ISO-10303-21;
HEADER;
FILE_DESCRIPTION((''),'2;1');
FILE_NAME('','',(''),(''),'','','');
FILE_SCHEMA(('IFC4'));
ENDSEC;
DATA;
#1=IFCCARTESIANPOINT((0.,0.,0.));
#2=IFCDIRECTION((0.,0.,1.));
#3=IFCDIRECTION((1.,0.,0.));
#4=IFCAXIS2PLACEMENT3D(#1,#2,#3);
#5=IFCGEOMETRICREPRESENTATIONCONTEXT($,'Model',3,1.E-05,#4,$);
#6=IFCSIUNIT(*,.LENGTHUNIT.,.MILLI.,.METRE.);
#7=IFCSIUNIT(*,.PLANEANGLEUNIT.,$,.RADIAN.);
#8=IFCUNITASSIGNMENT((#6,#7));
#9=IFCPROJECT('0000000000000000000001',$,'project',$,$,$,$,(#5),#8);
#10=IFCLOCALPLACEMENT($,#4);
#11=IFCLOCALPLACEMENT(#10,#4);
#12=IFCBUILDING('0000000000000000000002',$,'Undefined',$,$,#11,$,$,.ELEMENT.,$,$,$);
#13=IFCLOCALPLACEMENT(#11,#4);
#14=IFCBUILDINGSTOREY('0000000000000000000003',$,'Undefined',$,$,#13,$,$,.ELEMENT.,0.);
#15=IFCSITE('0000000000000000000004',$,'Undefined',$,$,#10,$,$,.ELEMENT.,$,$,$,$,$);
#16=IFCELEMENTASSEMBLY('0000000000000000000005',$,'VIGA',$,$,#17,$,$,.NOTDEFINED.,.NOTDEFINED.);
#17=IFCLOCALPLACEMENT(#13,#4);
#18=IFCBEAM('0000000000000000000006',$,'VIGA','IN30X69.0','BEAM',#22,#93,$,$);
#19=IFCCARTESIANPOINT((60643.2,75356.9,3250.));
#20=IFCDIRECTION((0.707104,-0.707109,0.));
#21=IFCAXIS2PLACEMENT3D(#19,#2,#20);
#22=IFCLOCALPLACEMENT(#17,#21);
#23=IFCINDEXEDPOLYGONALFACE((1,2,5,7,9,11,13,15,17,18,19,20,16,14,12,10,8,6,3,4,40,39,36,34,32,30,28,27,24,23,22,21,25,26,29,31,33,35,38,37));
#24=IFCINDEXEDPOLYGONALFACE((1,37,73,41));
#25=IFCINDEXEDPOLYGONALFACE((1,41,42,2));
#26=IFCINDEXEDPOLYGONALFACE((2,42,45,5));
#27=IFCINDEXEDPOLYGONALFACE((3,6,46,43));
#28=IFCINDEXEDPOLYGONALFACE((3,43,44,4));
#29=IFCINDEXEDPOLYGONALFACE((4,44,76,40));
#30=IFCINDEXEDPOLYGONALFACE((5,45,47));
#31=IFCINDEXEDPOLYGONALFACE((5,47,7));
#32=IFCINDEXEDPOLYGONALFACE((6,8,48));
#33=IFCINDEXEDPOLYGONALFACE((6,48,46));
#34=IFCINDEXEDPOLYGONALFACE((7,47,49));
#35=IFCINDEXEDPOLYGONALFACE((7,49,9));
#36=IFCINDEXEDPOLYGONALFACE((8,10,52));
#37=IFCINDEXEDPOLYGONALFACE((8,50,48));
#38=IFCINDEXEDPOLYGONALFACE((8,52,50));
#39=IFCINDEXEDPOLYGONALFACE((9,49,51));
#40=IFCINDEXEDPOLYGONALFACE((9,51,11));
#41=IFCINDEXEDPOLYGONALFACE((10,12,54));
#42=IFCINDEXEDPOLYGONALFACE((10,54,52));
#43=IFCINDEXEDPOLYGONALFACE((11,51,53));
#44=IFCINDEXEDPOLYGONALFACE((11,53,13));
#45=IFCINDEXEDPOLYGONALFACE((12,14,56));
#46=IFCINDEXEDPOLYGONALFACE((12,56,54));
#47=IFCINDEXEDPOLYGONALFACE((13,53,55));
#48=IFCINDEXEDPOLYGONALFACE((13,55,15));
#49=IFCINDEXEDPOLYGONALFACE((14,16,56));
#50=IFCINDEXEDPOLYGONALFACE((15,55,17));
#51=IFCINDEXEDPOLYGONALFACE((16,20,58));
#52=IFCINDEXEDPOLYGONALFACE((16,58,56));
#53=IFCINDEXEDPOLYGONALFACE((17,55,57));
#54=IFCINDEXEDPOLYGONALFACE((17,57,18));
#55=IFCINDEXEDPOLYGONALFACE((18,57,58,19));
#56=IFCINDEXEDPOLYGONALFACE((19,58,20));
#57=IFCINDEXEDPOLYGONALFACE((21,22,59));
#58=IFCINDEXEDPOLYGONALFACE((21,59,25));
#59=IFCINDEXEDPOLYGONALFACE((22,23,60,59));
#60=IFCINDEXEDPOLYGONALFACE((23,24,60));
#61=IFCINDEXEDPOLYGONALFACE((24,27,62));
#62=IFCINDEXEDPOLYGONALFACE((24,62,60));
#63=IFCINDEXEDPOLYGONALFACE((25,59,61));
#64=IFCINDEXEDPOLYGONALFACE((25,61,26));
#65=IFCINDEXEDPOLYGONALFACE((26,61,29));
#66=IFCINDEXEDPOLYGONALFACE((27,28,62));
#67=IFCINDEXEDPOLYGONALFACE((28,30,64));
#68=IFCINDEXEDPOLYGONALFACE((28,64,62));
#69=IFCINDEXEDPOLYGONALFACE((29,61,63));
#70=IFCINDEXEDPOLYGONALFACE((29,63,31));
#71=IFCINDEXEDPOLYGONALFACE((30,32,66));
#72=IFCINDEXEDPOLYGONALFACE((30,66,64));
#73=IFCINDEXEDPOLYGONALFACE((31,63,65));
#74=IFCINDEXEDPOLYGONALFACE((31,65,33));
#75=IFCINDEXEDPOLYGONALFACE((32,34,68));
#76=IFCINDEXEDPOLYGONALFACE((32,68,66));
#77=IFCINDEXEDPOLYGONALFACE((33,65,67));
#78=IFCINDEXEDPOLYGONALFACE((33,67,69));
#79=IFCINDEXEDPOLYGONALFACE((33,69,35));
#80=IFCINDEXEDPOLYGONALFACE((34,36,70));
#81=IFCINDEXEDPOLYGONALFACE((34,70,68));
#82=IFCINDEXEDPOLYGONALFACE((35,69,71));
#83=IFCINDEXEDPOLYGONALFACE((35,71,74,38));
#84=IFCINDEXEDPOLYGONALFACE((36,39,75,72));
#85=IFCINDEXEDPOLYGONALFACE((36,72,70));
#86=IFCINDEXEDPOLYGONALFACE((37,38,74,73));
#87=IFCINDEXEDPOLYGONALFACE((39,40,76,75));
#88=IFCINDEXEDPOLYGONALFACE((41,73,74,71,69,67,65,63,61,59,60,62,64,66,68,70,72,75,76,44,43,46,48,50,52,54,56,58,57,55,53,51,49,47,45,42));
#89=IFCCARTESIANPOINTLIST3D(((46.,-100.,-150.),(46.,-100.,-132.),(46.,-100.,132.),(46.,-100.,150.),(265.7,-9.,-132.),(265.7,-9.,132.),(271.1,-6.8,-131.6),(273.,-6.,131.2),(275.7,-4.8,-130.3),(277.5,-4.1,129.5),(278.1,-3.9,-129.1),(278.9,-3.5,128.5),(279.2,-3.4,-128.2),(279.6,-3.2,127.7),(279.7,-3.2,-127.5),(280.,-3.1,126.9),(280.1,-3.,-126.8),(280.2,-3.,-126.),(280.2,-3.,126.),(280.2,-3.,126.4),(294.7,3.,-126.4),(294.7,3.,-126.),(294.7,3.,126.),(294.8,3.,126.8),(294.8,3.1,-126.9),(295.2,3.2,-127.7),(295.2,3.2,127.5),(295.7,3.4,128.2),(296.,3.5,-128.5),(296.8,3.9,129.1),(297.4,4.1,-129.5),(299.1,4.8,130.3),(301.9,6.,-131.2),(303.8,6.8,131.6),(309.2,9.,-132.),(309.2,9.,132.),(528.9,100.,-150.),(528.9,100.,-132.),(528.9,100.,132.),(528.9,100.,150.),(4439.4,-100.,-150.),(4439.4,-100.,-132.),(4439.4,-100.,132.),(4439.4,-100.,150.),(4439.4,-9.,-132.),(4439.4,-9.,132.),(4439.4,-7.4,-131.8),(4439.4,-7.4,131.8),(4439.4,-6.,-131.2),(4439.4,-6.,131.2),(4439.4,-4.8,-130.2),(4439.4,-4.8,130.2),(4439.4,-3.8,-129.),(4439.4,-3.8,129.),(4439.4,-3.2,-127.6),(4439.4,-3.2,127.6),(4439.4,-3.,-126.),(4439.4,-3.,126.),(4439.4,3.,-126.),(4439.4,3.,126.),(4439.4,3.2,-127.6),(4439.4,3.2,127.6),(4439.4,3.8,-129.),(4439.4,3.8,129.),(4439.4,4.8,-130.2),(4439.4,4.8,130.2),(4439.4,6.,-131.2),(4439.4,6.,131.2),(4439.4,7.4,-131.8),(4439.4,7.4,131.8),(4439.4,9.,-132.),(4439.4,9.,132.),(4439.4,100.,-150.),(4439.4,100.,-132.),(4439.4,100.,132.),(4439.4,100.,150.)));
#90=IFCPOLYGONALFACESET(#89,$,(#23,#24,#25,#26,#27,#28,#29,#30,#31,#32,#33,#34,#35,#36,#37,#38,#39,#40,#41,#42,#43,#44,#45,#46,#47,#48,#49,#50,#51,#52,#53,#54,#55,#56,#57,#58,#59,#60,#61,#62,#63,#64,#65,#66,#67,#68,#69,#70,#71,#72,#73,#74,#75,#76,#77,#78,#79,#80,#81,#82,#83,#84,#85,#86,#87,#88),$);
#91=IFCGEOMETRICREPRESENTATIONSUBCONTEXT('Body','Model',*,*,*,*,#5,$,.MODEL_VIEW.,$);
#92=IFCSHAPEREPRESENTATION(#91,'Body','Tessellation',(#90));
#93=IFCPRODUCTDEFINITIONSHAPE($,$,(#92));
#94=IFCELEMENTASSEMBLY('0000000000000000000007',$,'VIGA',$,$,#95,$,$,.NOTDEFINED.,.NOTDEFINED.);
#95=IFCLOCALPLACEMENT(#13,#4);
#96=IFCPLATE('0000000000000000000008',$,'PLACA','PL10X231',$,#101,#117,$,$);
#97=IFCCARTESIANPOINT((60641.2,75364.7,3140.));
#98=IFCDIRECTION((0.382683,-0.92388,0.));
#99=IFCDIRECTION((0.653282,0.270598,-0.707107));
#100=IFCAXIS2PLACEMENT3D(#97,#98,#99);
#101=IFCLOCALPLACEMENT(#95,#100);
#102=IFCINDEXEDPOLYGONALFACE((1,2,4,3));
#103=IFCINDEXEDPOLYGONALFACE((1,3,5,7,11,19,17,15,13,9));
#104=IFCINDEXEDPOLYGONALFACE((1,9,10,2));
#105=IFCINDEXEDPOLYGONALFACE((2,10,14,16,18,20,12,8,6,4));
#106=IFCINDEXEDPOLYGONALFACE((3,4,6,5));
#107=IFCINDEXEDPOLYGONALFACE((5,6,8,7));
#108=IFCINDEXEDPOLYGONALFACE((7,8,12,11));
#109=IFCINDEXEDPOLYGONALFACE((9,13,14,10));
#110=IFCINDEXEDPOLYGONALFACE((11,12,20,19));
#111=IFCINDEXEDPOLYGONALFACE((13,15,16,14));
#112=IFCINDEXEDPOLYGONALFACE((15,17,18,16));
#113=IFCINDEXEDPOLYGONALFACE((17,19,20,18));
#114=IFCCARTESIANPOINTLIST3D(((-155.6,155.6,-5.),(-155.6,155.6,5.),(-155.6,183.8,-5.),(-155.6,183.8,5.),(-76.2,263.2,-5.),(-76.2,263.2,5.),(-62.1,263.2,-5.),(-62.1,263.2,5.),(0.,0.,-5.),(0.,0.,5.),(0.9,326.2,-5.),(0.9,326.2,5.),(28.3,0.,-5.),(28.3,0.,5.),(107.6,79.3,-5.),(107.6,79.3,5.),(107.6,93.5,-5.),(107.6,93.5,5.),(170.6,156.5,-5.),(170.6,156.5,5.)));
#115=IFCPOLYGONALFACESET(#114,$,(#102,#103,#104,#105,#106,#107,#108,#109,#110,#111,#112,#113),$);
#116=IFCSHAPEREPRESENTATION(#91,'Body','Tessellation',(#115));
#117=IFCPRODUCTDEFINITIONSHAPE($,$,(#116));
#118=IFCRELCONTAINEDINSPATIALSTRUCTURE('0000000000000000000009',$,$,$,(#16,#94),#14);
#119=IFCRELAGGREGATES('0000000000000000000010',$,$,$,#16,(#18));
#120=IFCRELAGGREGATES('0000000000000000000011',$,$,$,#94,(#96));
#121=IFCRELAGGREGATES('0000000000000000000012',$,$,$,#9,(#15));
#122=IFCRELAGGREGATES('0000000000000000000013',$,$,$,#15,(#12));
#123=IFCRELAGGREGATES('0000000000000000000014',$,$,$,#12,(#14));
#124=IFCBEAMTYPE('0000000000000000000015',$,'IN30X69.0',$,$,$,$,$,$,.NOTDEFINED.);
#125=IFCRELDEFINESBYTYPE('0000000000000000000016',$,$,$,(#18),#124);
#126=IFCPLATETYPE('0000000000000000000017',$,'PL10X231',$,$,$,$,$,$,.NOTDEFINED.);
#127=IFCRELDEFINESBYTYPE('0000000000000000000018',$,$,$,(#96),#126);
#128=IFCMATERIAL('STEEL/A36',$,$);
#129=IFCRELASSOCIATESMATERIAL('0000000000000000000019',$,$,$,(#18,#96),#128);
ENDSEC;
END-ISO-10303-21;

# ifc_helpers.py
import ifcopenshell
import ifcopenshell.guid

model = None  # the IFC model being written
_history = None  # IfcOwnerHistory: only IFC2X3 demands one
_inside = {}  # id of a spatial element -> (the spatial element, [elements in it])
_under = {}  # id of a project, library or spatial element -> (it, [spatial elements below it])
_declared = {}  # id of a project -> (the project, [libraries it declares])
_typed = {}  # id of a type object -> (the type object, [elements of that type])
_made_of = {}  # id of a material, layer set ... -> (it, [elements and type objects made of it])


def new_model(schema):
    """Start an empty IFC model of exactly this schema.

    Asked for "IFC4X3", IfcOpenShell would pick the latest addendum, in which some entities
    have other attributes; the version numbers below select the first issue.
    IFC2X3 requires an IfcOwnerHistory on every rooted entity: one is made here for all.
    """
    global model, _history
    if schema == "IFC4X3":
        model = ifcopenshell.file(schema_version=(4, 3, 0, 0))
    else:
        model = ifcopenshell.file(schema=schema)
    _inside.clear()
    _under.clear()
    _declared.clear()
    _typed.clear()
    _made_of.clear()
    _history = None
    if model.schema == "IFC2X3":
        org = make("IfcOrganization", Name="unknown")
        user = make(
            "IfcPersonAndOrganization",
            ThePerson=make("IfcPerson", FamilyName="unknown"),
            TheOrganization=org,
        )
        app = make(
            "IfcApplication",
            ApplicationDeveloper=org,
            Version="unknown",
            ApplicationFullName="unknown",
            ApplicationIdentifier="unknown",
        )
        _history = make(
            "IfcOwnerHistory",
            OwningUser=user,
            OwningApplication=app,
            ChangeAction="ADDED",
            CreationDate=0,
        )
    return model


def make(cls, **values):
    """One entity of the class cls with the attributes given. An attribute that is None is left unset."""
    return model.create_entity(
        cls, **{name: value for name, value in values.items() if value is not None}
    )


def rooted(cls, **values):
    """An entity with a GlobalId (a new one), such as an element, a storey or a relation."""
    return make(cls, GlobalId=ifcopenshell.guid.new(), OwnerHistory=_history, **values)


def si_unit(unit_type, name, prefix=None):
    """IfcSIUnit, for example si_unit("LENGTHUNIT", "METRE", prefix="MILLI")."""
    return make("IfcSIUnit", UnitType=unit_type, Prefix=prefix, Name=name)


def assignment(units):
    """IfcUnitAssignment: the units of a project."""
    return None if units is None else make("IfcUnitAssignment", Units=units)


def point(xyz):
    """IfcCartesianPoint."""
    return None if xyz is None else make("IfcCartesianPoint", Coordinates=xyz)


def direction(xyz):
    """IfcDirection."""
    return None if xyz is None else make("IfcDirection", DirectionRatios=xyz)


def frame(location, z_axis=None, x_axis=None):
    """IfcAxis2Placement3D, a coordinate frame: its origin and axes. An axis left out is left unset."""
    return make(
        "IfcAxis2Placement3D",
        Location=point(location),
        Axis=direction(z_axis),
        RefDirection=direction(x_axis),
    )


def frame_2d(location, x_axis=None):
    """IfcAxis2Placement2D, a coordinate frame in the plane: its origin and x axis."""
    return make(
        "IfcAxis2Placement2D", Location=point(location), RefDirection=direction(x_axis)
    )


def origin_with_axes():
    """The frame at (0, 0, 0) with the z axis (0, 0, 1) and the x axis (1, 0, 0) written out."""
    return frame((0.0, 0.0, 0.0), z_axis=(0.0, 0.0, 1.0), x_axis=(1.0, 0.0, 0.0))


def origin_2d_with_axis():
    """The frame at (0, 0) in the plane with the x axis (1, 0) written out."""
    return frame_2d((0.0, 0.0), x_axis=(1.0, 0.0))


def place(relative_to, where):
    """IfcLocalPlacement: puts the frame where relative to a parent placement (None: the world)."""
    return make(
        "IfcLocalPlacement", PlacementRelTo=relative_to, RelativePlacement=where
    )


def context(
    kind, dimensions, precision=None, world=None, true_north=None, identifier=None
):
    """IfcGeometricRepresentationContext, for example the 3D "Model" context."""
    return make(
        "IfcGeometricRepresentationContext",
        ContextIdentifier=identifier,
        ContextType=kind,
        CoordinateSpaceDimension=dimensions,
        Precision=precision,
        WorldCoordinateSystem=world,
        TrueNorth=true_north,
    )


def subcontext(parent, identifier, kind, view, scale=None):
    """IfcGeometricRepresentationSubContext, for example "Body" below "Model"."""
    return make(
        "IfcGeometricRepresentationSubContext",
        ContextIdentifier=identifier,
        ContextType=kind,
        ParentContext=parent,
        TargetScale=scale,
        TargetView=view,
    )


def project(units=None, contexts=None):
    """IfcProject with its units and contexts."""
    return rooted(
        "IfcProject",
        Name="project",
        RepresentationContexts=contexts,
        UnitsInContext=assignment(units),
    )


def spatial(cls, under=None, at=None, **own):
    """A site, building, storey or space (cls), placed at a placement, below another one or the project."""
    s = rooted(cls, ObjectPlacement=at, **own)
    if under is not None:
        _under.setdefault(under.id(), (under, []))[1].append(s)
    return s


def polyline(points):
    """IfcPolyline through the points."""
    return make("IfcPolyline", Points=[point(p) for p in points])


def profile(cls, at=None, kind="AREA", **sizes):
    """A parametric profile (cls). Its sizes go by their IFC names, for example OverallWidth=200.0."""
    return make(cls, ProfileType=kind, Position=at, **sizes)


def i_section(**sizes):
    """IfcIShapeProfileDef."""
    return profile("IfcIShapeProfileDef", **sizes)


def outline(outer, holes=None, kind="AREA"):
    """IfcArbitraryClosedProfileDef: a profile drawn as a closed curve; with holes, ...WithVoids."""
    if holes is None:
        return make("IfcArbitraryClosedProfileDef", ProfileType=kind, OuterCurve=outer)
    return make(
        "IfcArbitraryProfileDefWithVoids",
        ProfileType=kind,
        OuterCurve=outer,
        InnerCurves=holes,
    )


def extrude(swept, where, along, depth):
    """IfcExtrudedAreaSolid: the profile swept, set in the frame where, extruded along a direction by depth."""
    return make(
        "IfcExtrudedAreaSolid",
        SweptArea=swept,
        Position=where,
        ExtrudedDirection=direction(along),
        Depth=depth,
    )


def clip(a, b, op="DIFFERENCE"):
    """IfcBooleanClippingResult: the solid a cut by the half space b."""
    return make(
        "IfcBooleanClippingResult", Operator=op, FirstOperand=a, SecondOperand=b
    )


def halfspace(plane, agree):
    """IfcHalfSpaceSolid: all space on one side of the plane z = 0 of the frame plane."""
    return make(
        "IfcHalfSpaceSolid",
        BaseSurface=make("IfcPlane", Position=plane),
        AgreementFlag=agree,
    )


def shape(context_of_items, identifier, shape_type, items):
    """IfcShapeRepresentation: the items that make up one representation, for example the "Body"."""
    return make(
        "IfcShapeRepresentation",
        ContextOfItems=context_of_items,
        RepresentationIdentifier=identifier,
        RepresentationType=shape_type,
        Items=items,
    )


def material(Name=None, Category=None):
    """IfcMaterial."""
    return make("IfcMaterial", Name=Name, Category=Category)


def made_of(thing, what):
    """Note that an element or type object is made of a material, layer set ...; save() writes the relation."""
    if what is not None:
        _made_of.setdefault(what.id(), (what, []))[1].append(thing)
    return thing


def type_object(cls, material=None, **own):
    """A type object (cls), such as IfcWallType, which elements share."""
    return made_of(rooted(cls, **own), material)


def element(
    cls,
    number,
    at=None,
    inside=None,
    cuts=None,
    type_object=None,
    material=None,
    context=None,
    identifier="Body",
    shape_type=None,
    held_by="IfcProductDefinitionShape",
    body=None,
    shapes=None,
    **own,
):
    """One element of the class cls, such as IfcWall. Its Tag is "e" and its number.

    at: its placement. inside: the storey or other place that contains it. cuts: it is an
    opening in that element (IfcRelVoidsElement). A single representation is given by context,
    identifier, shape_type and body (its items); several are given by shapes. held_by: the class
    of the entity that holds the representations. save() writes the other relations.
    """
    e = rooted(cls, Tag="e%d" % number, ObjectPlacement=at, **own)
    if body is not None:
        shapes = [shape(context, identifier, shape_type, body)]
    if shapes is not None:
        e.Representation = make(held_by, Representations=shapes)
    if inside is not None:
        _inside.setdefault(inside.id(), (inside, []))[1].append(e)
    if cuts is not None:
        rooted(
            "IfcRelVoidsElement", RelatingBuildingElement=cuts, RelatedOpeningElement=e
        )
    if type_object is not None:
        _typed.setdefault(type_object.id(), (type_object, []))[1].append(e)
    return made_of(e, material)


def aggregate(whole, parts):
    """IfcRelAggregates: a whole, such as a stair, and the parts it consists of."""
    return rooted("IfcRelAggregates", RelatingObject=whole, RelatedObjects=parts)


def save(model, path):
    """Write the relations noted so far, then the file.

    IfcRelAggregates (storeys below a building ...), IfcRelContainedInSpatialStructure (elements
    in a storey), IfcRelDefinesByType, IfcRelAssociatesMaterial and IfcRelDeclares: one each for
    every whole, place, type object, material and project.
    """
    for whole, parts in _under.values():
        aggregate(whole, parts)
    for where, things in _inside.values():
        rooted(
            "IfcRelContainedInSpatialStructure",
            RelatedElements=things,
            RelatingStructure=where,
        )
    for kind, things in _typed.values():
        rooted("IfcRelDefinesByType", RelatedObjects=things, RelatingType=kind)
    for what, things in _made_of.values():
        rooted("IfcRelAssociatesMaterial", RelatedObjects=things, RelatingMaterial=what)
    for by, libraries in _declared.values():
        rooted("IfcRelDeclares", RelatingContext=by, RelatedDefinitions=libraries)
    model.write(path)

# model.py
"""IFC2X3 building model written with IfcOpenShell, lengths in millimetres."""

from ifc_helpers import new_model, si_unit, frame, origin_with_axes, origin_2d_with_axis, place, context, subcontext, project, spatial, polyline, i_section, outline, extrude, clip, halfspace, material, type_object, element, aggregate, save


model = new_model("IFC2X3")

# Units and contexts
model_context = context("Model", 3, precision=1e-05, world=origin_with_axes())
body_context = subcontext(model_context, "Body", "Model", "MODEL_VIEW")
ifc_project = project(units=[si_unit("LENGTHUNIT", "METRE", prefix="MILLI"), si_unit("PLANEANGLEUNIT", "RADIAN")], contexts=[model_context])

# Site, building, storey
site_placement = place(None, origin_with_axes())
site = spatial("IfcSite", under=ifc_project, at=site_placement, Name="Undefined", CompositionType="ELEMENT")
building_placement = place(site_placement, origin_with_axes())
building = spatial("IfcBuilding", under=site, at=building_placement, Name="Undefined", CompositionType="ELEMENT")
storey_placement = place(building_placement, origin_with_axes())
storey = spatial("IfcBuildingStorey", under=building, at=storey_placement, Name="Undefined", CompositionType="ELEMENT", Elevation=0.0)

# Element assembly, beam
ifc_material_1 = material(Name="STEEL/A36")
assembly_1_placement = place(storey_placement, origin_with_axes())
assembly_1 = element("IfcElementAssembly", 1, at=assembly_1_placement, inside=storey, Name="VIGA", AssemblyPlace="NOTDEFINED", PredefinedType="NOTDEFINED")
beam_type_1 = type_object("IfcBeamType", Name="IN30X69.0", PredefinedType="NOTDEFINED")
beam_1_placement = place(assembly_1_placement, frame((60643.2, 75356.9, 3250.0), z_axis=(0.0, 0.0, 1.0), x_axis=(0.707104, -0.707109, 0.0)))
beam_1 = element("IfcBeam", 2, at=beam_1_placement, type_object=beam_type_1, material=ifc_material_1, Name="VIGA", Description="IN30X69.0", ObjectType="BEAM", context=body_context, shape_type="Clipping", body=[
    clip(extrude(i_section(OverallWidth=200.0, OverallDepth=300.0, WebThickness=6.0, FlangeThickness=18.0, FilletRadius=6.0, at=origin_2d_with_axis()), frame((4439.4, 0.0, 0.0), z_axis=(-1.0, 0.0, 0.0), x_axis=(0.0, -1.0, 0.0)), (0.0, 0.0, 1.0), 4496.8), halfspace(frame((48.8, -98.9, 250.0), z_axis=(-0.382685, 0.923879, 0.0), x_axis=(-0.923879, -0.382685, 0.0)), False)),
])
aggregate(assembly_1, [beam_1])

# Element assembly, plate
assembly_2_placement = place(storey_placement, origin_with_axes())
assembly_2 = element("IfcElementAssembly", 3, at=assembly_2_placement, inside=storey, Name="VIGA", AssemblyPlace="NOTDEFINED", PredefinedType="NOTDEFINED")
plate_type_1 = type_object("IfcPlateType", Name="PL10X231", PredefinedType="NOTDEFINED")
plate_1_placement = place(assembly_2_placement, frame((60641.2, 75364.7, 3140.0), z_axis=(0.382683, -0.92388, 0.0), x_axis=(0.653282, 0.270598, -0.707107)))
plate_1 = element("IfcPlate", 4, at=plate_1_placement, type_object=plate_type_1, material=ifc_material_1, Name="PLACA", Description="PL10X231", context=body_context, shape_type="SweptSolid", body=[
    extrude(outline(polyline([(0.0, 0.0), (28.3, 0.0), (107.6, 79.3), (107.6, 79.3), (107.6, 93.5), (170.6, 156.5), (0.9, 326.2), (-62.1, 263.2), (-76.2, 263.2), (-76.2, 263.2), (-155.6, 183.8), (-155.6, 155.6), (0.0, 0.0)])), frame((0.0, 0.0, -5.0), z_axis=(0.0, 0.0, 1.0), x_axis=(1.0, 0.0, 0.0)), (0.0, 0.0, 1.0), 10.0),
])
aggregate(assembly_2, [plate_1])

save(model, "model.ifc")
